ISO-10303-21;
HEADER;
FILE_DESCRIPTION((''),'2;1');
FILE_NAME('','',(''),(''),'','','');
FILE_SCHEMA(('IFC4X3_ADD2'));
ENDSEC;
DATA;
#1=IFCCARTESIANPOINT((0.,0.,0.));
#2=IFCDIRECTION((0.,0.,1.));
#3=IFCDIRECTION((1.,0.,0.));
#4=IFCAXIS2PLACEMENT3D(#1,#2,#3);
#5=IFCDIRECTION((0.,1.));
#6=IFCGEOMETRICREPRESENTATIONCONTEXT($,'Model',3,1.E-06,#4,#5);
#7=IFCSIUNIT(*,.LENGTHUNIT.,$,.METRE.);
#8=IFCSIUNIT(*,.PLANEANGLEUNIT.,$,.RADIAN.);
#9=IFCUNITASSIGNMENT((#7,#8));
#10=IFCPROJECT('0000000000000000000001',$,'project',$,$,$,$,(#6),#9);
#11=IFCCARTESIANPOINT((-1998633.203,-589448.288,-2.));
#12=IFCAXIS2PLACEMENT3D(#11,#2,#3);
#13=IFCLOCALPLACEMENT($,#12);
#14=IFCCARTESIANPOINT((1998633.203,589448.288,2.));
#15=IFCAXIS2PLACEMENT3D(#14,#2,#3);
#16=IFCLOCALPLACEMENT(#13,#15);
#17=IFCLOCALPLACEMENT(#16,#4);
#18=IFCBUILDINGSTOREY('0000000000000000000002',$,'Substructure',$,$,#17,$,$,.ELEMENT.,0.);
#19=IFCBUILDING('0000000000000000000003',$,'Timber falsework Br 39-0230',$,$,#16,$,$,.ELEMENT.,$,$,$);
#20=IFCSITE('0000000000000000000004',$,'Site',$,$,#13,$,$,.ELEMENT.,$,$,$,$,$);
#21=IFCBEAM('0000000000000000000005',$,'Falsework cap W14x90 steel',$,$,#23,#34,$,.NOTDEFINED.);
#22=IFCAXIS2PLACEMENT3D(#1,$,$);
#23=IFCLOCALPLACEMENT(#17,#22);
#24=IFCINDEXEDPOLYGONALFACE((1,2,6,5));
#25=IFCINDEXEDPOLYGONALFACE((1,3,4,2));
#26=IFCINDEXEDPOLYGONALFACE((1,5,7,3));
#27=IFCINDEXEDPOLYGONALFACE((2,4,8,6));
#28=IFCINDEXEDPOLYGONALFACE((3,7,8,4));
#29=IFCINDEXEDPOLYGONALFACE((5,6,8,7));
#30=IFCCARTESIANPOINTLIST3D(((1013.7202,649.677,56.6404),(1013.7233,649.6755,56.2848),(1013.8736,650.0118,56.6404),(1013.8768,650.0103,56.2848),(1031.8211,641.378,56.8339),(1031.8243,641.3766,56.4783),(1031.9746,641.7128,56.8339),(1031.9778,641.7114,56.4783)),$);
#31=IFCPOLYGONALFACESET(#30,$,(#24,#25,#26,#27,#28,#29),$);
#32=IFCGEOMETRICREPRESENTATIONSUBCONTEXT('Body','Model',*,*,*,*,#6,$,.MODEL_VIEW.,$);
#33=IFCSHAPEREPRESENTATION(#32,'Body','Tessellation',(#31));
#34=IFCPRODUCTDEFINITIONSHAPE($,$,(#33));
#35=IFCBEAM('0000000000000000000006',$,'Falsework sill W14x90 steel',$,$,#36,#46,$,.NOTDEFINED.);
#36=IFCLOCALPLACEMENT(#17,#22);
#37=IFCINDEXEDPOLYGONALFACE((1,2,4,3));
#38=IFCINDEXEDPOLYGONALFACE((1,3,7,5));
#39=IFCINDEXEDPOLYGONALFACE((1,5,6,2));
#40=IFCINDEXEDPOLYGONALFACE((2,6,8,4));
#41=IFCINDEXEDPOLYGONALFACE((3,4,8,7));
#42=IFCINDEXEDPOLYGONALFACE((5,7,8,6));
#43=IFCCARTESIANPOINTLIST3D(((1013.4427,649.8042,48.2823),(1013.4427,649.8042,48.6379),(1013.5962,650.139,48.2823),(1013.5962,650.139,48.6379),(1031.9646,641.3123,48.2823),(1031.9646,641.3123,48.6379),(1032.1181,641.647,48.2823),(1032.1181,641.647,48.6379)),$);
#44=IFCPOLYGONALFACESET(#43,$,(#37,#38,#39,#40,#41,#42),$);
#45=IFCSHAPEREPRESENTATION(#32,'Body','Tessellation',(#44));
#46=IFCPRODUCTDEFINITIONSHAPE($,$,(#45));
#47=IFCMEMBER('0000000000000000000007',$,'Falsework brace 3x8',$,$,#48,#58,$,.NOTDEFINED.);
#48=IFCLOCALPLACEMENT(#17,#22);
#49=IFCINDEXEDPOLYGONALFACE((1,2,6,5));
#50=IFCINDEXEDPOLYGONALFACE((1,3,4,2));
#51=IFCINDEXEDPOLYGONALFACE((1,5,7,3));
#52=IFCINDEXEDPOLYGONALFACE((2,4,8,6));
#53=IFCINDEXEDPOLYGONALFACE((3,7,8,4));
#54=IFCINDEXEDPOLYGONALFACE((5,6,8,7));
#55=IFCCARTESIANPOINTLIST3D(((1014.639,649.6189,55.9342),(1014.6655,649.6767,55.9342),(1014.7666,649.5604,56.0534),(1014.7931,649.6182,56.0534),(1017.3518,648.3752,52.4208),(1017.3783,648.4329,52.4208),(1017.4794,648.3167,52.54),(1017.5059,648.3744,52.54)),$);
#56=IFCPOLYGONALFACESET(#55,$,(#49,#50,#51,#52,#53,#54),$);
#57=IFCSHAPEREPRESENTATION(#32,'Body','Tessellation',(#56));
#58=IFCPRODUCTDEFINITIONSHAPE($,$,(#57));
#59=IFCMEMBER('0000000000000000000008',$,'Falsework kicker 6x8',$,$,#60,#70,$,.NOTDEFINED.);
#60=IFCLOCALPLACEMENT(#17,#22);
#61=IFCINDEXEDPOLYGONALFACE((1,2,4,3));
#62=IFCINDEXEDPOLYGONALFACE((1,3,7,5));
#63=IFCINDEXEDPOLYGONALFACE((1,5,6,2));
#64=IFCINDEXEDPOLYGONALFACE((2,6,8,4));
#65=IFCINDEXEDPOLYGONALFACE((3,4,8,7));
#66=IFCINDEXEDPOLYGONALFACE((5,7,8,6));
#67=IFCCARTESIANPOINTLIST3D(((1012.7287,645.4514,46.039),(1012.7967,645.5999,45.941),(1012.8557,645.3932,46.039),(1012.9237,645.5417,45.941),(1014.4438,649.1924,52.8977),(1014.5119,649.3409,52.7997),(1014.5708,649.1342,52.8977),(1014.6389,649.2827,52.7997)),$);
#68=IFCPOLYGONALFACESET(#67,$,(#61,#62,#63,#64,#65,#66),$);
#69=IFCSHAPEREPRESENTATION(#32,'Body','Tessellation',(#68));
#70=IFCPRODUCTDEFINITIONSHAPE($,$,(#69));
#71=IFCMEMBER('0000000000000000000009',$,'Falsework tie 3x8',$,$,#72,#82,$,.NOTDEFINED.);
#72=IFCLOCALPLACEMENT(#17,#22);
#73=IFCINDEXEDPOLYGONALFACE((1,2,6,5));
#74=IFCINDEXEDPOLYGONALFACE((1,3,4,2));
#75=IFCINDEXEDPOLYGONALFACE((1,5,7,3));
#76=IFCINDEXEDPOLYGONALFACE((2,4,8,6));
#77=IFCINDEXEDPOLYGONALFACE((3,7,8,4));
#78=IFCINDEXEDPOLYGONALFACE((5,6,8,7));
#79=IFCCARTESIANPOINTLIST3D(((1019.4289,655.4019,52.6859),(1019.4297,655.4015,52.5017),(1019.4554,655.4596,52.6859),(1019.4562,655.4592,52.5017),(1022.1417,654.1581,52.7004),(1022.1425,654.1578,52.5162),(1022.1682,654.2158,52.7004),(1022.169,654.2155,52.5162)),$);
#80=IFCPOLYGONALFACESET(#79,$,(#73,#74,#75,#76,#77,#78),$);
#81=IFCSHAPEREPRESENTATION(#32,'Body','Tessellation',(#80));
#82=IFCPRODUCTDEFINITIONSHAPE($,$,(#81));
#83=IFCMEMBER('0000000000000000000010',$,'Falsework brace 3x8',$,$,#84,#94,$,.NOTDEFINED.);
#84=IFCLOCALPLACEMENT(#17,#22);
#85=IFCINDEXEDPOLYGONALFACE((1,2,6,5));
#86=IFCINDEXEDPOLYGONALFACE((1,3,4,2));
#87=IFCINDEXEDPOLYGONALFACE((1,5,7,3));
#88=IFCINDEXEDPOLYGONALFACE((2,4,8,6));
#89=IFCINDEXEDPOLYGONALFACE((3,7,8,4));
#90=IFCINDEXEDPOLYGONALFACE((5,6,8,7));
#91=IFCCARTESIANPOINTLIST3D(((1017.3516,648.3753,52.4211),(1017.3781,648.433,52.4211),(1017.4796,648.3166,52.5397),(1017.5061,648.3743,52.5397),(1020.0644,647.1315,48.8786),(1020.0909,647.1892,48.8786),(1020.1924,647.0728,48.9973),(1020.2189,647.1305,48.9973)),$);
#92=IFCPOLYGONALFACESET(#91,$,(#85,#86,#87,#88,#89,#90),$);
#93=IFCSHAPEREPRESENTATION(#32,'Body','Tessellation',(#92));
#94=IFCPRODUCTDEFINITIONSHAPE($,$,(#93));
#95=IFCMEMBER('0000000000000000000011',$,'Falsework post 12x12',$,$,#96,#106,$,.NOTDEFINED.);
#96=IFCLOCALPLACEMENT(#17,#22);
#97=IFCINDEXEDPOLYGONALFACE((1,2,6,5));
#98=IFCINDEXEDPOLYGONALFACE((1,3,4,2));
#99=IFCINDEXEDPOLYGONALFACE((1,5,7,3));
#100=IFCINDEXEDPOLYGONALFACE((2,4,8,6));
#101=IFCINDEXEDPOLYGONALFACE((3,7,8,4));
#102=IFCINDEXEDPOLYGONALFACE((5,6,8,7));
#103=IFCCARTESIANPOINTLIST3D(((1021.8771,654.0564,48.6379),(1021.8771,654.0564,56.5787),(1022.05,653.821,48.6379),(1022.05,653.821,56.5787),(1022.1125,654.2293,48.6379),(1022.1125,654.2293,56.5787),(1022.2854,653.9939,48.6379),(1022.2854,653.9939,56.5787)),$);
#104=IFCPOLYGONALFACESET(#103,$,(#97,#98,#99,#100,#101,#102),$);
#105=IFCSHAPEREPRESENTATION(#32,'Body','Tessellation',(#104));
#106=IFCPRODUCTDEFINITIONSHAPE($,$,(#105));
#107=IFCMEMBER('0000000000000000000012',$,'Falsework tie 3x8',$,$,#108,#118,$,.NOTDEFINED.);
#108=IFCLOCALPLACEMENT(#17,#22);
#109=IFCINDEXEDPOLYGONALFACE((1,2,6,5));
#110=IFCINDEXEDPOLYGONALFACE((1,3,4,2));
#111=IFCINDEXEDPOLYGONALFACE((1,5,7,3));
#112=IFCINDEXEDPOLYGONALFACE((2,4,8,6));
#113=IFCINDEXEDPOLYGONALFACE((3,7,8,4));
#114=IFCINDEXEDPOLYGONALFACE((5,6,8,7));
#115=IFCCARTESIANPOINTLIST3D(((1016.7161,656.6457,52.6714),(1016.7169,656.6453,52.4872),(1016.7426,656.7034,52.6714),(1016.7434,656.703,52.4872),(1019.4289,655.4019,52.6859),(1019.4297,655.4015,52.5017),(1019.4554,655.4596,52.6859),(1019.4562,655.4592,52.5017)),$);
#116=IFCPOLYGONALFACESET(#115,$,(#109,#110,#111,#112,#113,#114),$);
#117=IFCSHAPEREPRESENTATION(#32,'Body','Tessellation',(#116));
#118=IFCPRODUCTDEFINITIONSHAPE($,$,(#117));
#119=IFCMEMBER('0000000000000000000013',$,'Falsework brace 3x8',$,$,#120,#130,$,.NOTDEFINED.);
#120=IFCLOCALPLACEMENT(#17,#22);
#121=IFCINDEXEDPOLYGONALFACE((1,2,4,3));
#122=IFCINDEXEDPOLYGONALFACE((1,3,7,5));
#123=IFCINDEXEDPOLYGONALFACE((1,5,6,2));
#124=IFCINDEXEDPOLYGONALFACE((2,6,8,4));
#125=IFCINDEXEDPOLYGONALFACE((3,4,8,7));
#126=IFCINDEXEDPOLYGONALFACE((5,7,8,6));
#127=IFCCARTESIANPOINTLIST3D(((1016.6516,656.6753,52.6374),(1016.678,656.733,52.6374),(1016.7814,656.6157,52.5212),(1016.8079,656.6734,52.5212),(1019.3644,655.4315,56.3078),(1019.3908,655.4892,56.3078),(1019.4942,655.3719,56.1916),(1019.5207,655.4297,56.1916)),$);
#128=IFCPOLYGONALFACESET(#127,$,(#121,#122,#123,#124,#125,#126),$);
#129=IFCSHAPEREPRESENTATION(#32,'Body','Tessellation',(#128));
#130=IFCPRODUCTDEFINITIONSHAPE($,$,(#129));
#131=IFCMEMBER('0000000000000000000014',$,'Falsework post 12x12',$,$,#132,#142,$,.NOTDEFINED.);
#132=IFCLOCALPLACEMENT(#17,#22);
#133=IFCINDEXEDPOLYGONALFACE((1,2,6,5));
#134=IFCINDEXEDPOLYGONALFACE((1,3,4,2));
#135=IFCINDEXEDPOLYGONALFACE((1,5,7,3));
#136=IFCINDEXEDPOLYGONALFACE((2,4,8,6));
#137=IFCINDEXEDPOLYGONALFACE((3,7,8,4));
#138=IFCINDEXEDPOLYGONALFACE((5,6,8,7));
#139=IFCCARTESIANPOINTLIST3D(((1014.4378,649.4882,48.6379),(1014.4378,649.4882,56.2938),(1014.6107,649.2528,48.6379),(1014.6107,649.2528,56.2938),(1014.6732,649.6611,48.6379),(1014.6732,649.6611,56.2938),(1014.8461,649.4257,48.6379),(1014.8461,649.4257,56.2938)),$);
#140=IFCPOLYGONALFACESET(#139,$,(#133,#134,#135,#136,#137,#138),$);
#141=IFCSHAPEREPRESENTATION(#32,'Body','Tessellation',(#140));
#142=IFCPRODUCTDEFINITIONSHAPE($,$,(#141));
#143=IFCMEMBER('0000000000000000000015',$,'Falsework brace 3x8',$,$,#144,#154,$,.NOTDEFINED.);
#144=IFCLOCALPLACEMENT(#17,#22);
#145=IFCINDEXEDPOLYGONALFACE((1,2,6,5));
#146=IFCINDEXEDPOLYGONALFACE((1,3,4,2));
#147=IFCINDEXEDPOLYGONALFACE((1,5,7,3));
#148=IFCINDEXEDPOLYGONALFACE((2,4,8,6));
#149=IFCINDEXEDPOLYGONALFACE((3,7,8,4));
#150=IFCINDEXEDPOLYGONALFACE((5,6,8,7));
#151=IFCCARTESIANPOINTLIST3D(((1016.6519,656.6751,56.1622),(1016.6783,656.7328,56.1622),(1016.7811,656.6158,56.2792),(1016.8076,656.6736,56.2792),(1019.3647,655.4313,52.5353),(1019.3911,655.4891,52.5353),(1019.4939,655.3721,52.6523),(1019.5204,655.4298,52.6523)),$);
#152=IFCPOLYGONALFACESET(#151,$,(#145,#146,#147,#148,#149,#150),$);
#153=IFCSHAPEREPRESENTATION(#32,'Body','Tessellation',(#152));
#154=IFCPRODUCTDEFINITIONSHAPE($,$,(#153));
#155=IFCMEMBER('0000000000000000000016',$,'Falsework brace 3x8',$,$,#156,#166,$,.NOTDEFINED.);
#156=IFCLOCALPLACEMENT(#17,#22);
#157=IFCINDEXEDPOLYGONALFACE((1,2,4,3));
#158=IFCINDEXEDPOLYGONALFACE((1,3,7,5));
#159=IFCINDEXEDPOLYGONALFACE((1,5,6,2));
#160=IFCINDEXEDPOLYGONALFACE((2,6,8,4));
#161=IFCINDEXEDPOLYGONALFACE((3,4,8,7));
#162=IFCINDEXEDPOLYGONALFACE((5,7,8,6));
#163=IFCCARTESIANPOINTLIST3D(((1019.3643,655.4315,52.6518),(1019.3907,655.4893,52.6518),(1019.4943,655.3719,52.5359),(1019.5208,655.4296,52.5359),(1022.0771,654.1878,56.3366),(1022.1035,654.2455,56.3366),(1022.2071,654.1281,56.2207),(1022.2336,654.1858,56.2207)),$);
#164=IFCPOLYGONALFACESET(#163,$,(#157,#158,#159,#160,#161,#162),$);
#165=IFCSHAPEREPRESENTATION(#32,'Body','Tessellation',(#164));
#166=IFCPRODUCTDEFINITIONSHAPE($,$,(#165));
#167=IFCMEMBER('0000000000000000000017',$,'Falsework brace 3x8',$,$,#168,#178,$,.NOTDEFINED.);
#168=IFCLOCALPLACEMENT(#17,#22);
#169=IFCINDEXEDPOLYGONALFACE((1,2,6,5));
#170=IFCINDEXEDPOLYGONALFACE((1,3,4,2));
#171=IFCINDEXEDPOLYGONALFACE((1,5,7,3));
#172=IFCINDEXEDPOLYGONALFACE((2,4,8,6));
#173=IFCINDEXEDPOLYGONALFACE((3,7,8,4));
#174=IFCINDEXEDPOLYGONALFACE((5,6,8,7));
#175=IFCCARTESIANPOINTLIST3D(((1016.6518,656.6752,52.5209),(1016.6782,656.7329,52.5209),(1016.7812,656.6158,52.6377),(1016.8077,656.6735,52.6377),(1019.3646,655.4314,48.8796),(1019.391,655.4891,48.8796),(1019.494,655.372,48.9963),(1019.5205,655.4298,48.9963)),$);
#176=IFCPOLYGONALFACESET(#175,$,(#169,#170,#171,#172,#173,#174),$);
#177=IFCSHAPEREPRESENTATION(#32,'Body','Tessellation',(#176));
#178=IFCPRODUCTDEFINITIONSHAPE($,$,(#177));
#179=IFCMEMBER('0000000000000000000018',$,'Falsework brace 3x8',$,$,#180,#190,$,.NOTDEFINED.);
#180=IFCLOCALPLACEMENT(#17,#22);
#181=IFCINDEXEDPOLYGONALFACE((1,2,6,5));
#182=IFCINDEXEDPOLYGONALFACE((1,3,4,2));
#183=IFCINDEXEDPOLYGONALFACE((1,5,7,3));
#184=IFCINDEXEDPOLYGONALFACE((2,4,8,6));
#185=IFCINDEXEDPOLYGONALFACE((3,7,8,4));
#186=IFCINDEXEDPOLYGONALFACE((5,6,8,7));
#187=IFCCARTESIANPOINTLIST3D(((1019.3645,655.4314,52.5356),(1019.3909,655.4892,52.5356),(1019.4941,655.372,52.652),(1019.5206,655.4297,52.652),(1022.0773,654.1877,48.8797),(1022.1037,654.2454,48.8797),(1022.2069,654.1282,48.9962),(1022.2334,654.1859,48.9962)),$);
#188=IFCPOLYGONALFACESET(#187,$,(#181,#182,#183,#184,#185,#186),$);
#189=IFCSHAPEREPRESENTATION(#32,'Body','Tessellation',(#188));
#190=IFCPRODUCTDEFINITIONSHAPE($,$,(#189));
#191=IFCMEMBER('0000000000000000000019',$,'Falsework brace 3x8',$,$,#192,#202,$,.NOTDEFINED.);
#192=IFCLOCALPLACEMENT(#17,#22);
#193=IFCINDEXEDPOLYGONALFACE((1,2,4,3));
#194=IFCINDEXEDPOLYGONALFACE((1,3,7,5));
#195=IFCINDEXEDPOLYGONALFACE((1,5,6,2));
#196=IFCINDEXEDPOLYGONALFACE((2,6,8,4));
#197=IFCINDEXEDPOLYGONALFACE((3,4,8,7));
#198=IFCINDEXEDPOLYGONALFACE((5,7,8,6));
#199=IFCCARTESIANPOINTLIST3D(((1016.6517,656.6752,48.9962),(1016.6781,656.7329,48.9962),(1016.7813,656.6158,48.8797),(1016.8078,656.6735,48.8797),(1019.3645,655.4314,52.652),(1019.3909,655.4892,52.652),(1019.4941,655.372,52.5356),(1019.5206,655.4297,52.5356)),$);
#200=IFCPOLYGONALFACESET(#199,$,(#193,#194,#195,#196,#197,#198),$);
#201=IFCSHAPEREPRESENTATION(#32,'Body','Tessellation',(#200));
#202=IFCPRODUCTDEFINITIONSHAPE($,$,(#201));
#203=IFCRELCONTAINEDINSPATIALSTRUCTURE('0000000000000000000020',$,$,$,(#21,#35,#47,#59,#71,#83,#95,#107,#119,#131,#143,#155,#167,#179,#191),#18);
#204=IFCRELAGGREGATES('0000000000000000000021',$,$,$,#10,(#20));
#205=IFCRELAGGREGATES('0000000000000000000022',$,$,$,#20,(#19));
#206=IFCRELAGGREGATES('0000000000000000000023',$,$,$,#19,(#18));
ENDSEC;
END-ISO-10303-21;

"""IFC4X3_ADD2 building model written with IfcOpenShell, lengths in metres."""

from ifc_helpers import new_model, si_unit, direction, frame, frame_2d, origin, origin_with_axes, origin_2d, place, context, subcontext, project, spatial, rectangle, extrude, element, save


model = new_model("IFC4X3_ADD2")

# Units and contexts
model_context = context("Model", 3, precision=1e-06, world=origin_with_axes(), true_north=direction((0.0, 1.0)))
body_context = subcontext(model_context, "Body", "Model", "MODEL_VIEW")
ifc_project = project(units=[si_unit("LENGTHUNIT", "METRE"), si_unit("PLANEANGLEUNIT", "RADIAN")], contexts=[model_context])

# Site, building, storey
site_placement = place(None, frame((-1998633.203, -589448.288, -2.0), z_axis=(0.0, 0.0, 1.0), x_axis=(1.0, 0.0, 0.0)))
site = spatial("IfcSite", under=ifc_project, at=site_placement, Name="Site", CompositionType="ELEMENT")
building_placement = place(site_placement, frame((1998633.203, 589448.288, 2.0), z_axis=(0.0, 0.0, 1.0), x_axis=(1.0, 0.0, 0.0)))
building = spatial("IfcBuilding", under=site, at=building_placement, Name="Timber falsework Br 39-0230", CompositionType="ELEMENT")
storey_placement = place(building_placement, origin_with_axes())
storey = spatial("IfcBuildingStorey", under=building, at=storey_placement, Name="Substructure", CompositionType="ELEMENT", Elevation=0.0)

# Beams
beam_1_placement = place(storey_placement, frame((1013.8, 649.8429, 56.2848), z_axis=(0.908971, -0.416746, 0.009717), x_axis=(0.416765, 0.909014, 0.0)))
element("IfcBeam", 1, at=beam_1_placement, inside=storey, Name="Falsework cap W14x90 steel", PredefinedType="NOTDEFINED", context=body_context, shape_type="SweptSolid", body=[
    extrude(rectangle(XDim=0.3683, YDim=0.3556, at=frame_2d((0.0, 0.1778))), origin(), (0.0, 0.0, 1.0), 19.9137),
])
beam_2_placement = place(storey_placement, frame((1013.5194, 649.9716, 48.2823), z_axis=(0.909014, -0.416765, 0.0), x_axis=(0.416765, 0.909014, 0.0)))
element("IfcBeam", 2, at=beam_2_placement, inside=storey, Name="Falsework sill W14x90 steel", PredefinedType="NOTDEFINED", context=body_context, shape_type="SweptSolid", body=[
    extrude(rectangle(XDim=0.3683, YDim=0.3556, at=frame_2d((0.0, 0.1778))), origin(), (0.0, 0.0, 1.0), 20.3758),
])

# Members
member_1_placement = place(storey_placement, frame((1014.716, 649.6185, 55.9938), z_axis=(0.588484, -0.269808, -0.762162), x_axis=(0.416765, 0.909014, 0.0)))
element("IfcMember", 3, at=member_1_placement, inside=storey, Name="Falsework brace 3x8", PredefinedType="NOTDEFINED", context=body_context, shape_type="SweptSolid", body=[
    extrude(rectangle(XDim=0.0635, YDim=0.1841, at=origin_2d()), origin(), (0.0, 0.0, 1.0), 4.6098),
])
member_2_placement = place(storey_placement, frame((1014.5414, 649.2376, 52.8487), z_axis=(-0.214434, -0.467707, -0.857478), x_axis=(0.909014, -0.416765, 0.0)))
element("IfcMember", 4, at=member_2_placement, inside=storey, Name="Falsework kicker 6x8", PredefinedType="NOTDEFINED", context=body_context, shape_type="SweptSolid", body=[
    extrude(rectangle(XDim=0.1397, YDim=0.1905, at=origin_2d()), origin(), (0.0, 0.0, 1.0), 7.9987),
])
member_3_placement = place(storey_placement, frame((1019.4425, 655.4306, 52.5938), z_axis=(0.909003, -0.41676, 0.004859), x_axis=(0.416765, 0.909014, 0.0)))
element("IfcMember", 5, at=member_3_placement, inside=storey, Name="Falsework tie 3x8", PredefinedType="NOTDEFINED", context=body_context, shape_type="SweptSolid", body=[
    extrude(rectangle(XDim=0.0635, YDim=0.1841, at=origin_2d()), origin(), (0.0, 0.0, 1.0), 2.9844),
])
member_4_placement = place(storey_placement, frame((1017.4289, 648.3748, 52.4804), z_axis=(0.585671, -0.268519, -0.764779), x_axis=(0.416765, 0.909014, 0.0)))
element("IfcMember", 6, at=member_4_placement, inside=storey, Name="Falsework brace 3x8", PredefinedType="NOTDEFINED", context=body_context, shape_type="SweptSolid", body=[
    extrude(rectangle(XDim=0.0635, YDim=0.1841, at=origin_2d()), origin(), (0.0, 0.0, 1.0), 4.632),
])
member_5_placement = place(storey_placement, frame((1022.0812, 654.0252, 48.6379), z_axis=(0.0, 0.0, 1.0), x_axis=(-0.805928, -0.592013, 0.0)))
element("IfcMember", 7, at=member_5_placement, inside=storey, Name="Falsework post 12x12", PredefinedType="NOTDEFINED", context=body_context, shape_type="SweptSolid", body=[
    extrude(rectangle(XDim=0.2921, YDim=0.2921, at=origin_2d()), origin(), (0.0, 0.0, 1.0), 7.9407),
])
member_6_placement = place(storey_placement, frame((1016.7297, 656.6743, 52.5793), z_axis=(0.909003, -0.41676, 0.004859), x_axis=(0.416765, 0.909014, 0.0)))
element("IfcMember", 8, at=member_6_placement, inside=storey, Name="Falsework tie 3x8", PredefinedType="NOTDEFINED", context=body_context, shape_type="SweptSolid", body=[
    extrude(rectangle(XDim=0.0635, YDim=0.1841, at=origin_2d()), origin(), (0.0, 0.0, 1.0), 2.9844),
])
member_7_placement = place(storey_placement, frame((1016.7297, 656.6743, 52.5793), z_axis=(0.573468, -0.262924, 0.77589), x_axis=(0.416765, 0.909014, 0.0)))
element("IfcMember", 9, at=member_7_placement, inside=storey, Name="Falsework brace 3x8", PredefinedType="NOTDEFINED", context=body_context, shape_type="SweptSolid", body=[
    extrude(rectangle(XDim=0.0635, YDim=0.1841, at=origin_2d()), origin(), (0.0, 0.0, 1.0), 4.7305),
])
member_8_placement = place(storey_placement, frame((1014.6419, 649.4569, 48.6379), z_axis=(0.0, 0.0, 1.0), x_axis=(-0.805928, -0.592013, 0.0)))
element("IfcMember", 10, at=member_8_placement, inside=storey, Name="Falsework post 12x12", PredefinedType="NOTDEFINED", context=body_context, shape_type="SweptSolid", body=[
    extrude(rectangle(XDim=0.2921, YDim=0.2921, at=origin_2d()), origin(), (0.0, 0.0, 1.0), 7.6559),
])
member_9_placement = place(storey_placement, frame((1016.7297, 656.6743, 56.2207), z_axis=(0.57758, -0.264809, -0.77219), x_axis=(0.416765, 0.909014, 0.0)))
element("IfcMember", 11, at=member_9_placement, inside=storey, Name="Falsework brace 3x8", PredefinedType="NOTDEFINED", context=body_context, shape_type="SweptSolid", body=[
    extrude(rectangle(XDim=0.0635, YDim=0.1841, at=origin_2d()), origin(), (0.0, 0.0, 1.0), 4.6969),
])
member_10_placement = place(storey_placement, frame((1019.4425, 655.4306, 52.5938), z_axis=(0.572107, -0.2623, 0.777105), x_axis=(0.416765, 0.909014, 0.0)))
element("IfcMember", 12, at=member_10_placement, inside=storey, Name="Falsework brace 3x8", PredefinedType="NOTDEFINED", context=body_context, shape_type="SweptSolid", body=[
    extrude(rectangle(XDim=0.0635, YDim=0.1841, at=origin_2d()), origin(), (0.0, 0.0, 1.0), 4.7418),
])
member_11_placement = place(storey_placement, frame((1016.7297, 656.6743, 52.5793), z_axis=(0.576205, -0.264179, -0.773432), x_axis=(0.416765, 0.909014, 0.0)))
element("IfcMember", 13, at=member_11_placement, inside=storey, Name="Falsework brace 3x8", PredefinedType="NOTDEFINED", context=body_context, shape_type="SweptSolid", body=[
    extrude(rectangle(XDim=0.0635, YDim=0.1841, at=origin_2d()), origin(), (0.0, 0.0, 1.0), 4.7081),
])
member_12_placement = place(storey_placement, frame((1019.4425, 655.4306, 52.5938), z_axis=(0.574834, -0.26355, -0.774665), x_axis=(0.416765, 0.909014, 0.0)))
element("IfcMember", 14, at=member_12_placement, inside=storey, Name="Falsework brace 3x8", PredefinedType="NOTDEFINED", context=body_context, shape_type="SweptSolid", body=[
    extrude(rectangle(XDim=0.0635, YDim=0.1841, at=origin_2d()), origin(), (0.0, 0.0, 1.0), 4.7193),
])
member_13_placement = place(storey_placement, frame((1016.7297, 656.6743, 48.9379), z_axis=(0.574834, -0.26355, 0.774665), x_axis=(0.416765, 0.909014, 0.0)))
element("IfcMember", 15, at=member_13_placement, inside=storey, Name="Falsework brace 3x8", PredefinedType="NOTDEFINED", context=body_context, shape_type="SweptSolid", body=[
    extrude(rectangle(XDim=0.0635, YDim=0.1841, at=origin_2d()), origin(), (0.0, 0.0, 1.0), 4.7193),
])

save(model, "model.ifc")
